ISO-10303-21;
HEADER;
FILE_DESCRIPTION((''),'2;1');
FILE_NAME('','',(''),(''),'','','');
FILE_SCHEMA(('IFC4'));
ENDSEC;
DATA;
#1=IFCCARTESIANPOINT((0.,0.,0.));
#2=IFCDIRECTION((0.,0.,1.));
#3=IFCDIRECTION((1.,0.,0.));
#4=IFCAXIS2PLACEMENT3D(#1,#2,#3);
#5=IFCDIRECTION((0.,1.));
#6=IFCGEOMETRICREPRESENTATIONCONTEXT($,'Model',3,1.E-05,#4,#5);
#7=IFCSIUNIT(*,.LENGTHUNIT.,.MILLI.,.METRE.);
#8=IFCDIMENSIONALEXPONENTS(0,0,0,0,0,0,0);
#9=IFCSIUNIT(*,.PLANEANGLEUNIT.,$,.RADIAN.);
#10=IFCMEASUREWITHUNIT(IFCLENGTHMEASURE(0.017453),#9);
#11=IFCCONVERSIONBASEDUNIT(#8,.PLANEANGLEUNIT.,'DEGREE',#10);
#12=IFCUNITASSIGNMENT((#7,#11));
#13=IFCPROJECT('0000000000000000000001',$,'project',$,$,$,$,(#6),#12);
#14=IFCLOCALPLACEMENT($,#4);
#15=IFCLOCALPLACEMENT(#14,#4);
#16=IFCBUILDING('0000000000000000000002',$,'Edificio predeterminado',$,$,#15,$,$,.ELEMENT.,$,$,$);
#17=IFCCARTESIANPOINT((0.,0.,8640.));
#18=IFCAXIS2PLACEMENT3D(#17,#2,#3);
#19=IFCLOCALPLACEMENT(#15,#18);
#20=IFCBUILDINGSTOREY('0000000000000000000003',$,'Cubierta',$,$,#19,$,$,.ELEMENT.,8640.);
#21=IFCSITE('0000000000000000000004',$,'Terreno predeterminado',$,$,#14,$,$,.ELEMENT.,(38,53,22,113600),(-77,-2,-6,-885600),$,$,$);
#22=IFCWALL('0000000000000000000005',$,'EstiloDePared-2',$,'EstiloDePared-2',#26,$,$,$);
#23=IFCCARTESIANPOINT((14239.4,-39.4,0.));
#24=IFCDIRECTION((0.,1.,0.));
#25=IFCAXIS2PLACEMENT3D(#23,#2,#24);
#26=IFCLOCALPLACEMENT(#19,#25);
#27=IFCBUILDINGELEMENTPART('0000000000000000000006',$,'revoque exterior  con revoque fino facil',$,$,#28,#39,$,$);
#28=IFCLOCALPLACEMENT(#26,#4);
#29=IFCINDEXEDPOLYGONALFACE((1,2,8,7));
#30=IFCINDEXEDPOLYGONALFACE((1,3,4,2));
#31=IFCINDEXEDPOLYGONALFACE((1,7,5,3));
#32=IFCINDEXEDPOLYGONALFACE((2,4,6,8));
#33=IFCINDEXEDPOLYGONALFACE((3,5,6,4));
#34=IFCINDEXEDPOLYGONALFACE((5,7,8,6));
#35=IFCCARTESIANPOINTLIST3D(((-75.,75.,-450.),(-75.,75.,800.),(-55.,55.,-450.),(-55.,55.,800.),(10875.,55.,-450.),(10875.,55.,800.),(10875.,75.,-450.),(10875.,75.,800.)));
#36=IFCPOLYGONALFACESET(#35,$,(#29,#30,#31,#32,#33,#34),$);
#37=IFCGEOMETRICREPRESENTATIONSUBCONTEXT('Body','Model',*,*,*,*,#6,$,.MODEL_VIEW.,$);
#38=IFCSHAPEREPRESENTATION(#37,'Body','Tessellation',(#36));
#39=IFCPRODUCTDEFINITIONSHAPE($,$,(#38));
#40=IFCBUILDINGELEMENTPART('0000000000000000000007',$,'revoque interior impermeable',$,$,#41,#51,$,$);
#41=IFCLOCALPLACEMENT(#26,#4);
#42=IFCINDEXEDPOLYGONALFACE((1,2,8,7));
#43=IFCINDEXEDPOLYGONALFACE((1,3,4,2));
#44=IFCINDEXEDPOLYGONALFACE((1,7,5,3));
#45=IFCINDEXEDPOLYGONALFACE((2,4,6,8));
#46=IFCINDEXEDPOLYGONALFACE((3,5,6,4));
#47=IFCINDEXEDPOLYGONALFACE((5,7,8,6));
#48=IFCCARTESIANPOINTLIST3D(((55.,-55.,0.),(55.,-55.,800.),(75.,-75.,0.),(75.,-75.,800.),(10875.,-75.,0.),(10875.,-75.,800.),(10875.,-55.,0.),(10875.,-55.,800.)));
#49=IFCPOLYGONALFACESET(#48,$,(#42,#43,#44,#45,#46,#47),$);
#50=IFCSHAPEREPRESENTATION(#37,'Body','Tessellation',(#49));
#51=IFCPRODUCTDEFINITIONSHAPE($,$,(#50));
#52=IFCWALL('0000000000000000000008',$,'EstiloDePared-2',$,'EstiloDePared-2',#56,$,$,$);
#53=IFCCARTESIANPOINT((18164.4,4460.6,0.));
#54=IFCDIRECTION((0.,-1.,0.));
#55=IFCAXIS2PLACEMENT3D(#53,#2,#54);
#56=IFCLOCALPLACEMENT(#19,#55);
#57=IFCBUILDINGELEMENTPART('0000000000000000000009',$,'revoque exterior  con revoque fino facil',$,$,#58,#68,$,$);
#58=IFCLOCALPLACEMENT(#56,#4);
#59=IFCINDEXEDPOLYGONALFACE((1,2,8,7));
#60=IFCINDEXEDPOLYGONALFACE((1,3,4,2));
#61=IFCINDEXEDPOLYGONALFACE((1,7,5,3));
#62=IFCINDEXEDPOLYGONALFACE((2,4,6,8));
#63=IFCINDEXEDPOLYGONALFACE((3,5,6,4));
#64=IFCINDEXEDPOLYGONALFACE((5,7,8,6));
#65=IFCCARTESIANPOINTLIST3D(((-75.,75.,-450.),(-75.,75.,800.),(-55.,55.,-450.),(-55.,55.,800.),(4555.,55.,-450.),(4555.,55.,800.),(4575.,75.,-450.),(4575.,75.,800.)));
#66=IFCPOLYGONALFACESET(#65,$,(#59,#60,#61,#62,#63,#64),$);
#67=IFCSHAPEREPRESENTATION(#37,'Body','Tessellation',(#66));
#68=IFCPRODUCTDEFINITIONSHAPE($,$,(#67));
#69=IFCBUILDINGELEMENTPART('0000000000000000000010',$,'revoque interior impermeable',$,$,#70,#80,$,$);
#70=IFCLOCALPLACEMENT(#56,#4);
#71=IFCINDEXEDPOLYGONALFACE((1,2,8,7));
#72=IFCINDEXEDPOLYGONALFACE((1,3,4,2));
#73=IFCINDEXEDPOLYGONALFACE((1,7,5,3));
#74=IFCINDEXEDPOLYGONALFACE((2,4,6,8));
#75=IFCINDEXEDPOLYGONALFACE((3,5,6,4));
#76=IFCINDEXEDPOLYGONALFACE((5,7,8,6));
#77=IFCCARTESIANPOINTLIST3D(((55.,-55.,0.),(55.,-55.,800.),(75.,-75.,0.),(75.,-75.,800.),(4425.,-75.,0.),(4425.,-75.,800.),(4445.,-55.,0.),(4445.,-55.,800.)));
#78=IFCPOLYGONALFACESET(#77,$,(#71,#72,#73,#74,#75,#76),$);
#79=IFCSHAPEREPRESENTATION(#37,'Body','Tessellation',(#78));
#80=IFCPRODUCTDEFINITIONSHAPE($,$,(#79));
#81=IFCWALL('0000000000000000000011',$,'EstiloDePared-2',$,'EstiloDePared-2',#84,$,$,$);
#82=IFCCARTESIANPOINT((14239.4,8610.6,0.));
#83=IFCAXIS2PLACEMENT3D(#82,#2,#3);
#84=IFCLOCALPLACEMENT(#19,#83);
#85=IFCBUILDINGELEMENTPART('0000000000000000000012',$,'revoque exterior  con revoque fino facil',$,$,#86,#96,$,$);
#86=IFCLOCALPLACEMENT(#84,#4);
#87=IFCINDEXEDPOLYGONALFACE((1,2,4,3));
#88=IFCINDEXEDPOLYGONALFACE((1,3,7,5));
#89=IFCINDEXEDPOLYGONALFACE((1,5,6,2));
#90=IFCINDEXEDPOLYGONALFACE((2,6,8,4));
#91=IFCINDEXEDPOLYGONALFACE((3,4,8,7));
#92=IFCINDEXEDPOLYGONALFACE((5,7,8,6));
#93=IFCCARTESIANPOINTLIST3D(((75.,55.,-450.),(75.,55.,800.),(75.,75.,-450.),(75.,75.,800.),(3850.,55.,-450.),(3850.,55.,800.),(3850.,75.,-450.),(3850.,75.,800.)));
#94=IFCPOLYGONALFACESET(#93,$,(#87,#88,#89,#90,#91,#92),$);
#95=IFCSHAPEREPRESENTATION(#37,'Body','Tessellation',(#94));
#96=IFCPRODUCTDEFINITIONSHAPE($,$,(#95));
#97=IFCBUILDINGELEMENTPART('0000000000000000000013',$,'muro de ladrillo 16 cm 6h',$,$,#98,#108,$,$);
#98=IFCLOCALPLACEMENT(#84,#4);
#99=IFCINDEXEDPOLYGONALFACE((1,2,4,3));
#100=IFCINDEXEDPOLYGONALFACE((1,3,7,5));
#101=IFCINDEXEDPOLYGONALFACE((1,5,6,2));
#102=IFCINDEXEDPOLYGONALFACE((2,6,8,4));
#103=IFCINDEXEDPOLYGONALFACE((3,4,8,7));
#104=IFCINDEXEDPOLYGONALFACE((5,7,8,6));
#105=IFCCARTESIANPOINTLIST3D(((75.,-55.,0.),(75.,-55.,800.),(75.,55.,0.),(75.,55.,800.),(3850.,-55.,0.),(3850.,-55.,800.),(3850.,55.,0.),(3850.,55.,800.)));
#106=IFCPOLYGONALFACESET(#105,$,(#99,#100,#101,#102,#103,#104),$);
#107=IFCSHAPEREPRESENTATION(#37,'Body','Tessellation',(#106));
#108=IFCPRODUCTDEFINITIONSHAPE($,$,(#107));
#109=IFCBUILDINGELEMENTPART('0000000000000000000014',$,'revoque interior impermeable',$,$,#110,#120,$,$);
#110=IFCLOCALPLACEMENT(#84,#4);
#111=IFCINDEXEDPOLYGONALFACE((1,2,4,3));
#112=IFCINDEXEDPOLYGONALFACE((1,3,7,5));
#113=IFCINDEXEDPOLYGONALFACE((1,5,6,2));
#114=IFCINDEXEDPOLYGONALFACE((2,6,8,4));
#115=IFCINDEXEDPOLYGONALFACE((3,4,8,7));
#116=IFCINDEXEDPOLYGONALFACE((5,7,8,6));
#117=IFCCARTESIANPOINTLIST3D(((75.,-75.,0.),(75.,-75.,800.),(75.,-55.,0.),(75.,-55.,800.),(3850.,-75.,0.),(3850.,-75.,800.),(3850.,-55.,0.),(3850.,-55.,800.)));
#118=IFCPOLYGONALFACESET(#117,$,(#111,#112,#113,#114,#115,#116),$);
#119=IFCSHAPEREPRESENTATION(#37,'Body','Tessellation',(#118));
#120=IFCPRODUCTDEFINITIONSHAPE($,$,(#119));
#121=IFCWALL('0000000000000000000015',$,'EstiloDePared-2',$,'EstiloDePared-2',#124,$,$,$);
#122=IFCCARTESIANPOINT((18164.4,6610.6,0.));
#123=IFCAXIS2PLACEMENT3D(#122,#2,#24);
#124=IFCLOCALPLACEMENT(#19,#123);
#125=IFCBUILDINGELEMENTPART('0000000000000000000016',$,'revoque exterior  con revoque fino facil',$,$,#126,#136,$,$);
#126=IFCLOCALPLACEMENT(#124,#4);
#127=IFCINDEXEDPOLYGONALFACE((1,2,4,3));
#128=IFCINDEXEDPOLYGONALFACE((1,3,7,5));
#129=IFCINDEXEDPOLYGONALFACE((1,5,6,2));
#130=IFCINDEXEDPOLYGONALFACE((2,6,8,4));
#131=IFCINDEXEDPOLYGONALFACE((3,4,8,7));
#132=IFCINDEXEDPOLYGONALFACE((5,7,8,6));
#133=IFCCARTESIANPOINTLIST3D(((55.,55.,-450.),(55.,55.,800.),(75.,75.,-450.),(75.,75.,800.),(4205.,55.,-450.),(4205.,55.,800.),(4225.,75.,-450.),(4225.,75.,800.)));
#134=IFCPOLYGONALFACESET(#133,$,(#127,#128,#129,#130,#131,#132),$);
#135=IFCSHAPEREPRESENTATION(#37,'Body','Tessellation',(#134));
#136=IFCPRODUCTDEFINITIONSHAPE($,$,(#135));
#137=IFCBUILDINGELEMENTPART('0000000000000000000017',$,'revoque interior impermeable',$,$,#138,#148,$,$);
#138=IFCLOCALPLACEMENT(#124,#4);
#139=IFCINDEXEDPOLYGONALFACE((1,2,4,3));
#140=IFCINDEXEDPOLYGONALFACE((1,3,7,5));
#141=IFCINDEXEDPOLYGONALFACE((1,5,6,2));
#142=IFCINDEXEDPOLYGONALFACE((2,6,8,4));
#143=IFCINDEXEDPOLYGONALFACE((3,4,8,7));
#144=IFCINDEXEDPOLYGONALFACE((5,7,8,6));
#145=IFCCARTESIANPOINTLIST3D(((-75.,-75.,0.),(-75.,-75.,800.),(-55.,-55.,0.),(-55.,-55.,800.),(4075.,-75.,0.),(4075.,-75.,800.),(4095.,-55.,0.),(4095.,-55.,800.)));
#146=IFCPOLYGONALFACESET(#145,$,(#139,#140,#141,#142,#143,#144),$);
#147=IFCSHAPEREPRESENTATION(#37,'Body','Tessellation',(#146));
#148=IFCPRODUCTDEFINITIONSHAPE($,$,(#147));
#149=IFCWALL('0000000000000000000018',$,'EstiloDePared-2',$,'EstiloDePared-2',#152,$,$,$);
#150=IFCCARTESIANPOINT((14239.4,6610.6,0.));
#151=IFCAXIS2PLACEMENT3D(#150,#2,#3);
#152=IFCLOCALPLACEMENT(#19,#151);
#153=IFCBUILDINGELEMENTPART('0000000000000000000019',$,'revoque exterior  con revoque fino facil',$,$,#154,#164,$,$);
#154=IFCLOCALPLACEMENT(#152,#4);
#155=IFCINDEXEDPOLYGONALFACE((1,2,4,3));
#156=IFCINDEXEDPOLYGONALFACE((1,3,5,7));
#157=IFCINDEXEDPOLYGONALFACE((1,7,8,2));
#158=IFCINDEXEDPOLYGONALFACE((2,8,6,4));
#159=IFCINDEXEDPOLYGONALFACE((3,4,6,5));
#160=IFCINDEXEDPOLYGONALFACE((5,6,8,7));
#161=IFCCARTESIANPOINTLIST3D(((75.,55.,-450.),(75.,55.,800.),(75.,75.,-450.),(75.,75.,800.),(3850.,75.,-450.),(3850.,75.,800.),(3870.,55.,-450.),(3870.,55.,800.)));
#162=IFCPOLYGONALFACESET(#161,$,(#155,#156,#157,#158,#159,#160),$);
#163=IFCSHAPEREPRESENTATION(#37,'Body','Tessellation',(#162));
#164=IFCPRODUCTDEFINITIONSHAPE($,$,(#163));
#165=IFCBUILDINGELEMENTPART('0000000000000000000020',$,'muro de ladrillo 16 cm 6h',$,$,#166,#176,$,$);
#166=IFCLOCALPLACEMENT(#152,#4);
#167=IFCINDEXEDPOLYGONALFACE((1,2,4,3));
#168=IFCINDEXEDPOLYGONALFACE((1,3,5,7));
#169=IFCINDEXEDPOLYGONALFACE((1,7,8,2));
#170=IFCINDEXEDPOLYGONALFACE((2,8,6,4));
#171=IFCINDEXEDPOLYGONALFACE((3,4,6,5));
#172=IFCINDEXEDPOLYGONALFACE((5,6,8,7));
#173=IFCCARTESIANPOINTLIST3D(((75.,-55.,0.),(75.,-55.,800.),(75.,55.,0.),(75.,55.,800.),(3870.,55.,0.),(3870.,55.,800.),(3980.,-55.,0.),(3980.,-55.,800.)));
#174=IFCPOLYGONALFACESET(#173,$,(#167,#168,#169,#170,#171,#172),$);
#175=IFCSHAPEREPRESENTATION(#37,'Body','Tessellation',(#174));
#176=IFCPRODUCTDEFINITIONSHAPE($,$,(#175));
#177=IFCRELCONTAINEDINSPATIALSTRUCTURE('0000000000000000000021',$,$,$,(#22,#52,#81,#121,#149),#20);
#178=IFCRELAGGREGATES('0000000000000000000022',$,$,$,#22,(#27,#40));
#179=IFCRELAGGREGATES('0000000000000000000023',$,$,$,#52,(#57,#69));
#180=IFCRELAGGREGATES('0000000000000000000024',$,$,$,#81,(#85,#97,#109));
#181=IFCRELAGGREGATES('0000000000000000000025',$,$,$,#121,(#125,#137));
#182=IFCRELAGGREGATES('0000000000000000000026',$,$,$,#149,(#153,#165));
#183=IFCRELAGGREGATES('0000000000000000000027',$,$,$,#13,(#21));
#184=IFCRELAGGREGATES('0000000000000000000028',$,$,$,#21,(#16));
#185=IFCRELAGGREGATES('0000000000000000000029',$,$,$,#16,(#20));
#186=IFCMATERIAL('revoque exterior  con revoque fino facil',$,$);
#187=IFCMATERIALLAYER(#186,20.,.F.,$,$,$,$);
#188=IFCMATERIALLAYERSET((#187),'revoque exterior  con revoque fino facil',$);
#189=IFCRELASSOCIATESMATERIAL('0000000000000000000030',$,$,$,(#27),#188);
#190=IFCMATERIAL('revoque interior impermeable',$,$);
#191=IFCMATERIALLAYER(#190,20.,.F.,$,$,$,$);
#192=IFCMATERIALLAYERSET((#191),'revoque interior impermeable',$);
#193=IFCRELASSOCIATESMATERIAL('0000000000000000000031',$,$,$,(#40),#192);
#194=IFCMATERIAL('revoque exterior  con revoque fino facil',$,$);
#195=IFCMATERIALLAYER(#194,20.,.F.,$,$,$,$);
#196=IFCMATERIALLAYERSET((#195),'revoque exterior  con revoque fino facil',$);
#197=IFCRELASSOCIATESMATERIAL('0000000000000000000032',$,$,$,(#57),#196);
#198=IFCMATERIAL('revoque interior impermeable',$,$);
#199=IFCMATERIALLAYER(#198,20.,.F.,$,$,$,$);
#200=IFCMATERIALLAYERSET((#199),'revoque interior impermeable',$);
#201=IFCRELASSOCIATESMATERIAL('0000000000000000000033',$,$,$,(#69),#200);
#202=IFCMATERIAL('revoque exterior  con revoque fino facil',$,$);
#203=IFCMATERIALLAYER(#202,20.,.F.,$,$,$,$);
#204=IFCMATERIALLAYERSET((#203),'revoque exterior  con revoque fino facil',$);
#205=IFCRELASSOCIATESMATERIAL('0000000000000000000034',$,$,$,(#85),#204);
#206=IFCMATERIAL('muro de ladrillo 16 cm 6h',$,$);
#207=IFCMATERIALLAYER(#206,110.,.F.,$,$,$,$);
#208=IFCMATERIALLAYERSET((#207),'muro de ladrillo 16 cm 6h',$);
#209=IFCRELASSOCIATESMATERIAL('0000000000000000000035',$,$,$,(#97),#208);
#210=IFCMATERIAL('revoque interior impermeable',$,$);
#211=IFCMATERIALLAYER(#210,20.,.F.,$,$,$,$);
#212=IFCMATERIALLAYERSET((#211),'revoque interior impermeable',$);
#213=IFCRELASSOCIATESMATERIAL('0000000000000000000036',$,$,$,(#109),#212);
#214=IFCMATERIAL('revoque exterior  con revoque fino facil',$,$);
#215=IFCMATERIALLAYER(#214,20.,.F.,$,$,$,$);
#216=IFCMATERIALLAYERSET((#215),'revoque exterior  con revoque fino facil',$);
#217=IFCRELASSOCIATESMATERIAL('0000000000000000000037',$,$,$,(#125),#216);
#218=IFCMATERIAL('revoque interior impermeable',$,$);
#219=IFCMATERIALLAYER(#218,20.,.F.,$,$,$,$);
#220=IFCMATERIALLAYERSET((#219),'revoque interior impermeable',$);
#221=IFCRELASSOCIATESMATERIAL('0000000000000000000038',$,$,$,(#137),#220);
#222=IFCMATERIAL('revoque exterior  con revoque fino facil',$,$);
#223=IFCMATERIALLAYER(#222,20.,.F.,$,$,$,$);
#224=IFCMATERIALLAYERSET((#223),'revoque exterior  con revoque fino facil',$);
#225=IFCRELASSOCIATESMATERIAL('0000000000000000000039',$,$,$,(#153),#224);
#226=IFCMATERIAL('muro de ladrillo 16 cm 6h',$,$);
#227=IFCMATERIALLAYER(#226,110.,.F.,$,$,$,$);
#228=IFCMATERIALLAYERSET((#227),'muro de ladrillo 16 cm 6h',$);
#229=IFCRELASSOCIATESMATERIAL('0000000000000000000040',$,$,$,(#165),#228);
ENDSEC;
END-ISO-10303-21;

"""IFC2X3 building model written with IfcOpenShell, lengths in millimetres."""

from ifc_helpers import new_model, entity, si_unit, converted_unit, direction, frame, origin_with_axes, place, context, subcontext, project, spatial, polyline, outline, extrude, material, layer, layer_set, layer_usage, element, aggregate, save


model = new_model("IFC2X3")

# Units and contexts
model_context = context("Model", 3, precision=1e-05, world=origin_with_axes(), true_north=direction((0.0, 1.0)))
body_context = subcontext(model_context, "Body", "Model", "MODEL_VIEW")
ifc_project = project(units=[si_unit("LENGTHUNIT", "METRE", prefix="MILLI"), converted_unit("PLANEANGLEUNIT", "DEGREE", entity("IfcLengthMeasure", 0.017453), si_unit("PLANEANGLEUNIT", "RADIAN"), dimensions=[0, 0, 0, 0, 0, 0, 0])], contexts=[model_context])

# Site, building, storey
site_placement = place(None, origin_with_axes())
site = spatial("IfcSite", under=ifc_project, at=site_placement, Name="Terreno predeterminado", CompositionType="ELEMENT", RefLatitude=(38, 53, 22, 113600), RefLongitude=(-77, -2, -6, -885600))
building_placement = place(site_placement, origin_with_axes())
building = spatial("IfcBuilding", under=site, at=building_placement, Name="Edificio predeterminado", CompositionType="ELEMENT")
storey_placement = place(building_placement, frame((0.0, 0.0, 8640.0), z_axis=(0.0, 0.0, 1.0), x_axis=(1.0, 0.0, 0.0)))
storey = spatial("IfcBuildingStorey", under=building, at=storey_placement, Name="Cubierta", CompositionType="ELEMENT", Elevation=8640.0)

# Walls, building element parts
wall_1_placement = place(storey_placement, frame((14239.4, -39.4, 0.0), z_axis=(0.0, 0.0, 1.0), x_axis=(0.0, 1.0, 0.0)))
wall_1 = element("IfcWall", 1, at=wall_1_placement, inside=storey, Name="EstiloDePared-2", ObjectType="EstiloDePared-2")
ifc_material_1 = material(Name="revoque exterior  con revoque fino facil")
ifc_layer_1 = layer(ifc_material_1, 20.0, ventilated=False)
ifc_layer_set_1 = layer_set([ifc_layer_1], Name="revoque exterior  con revoque fino facil")
ifc_layer_usage_1 = layer_usage(ifc_layer_set_1, "AXIS2", "NEGATIVE", -75.0)
building_element_part_1_placement = place(wall_1_placement, origin_with_axes())
building_element_part_1 = element("IfcBuildingElementPart", 2, at=building_element_part_1_placement, material=ifc_layer_usage_1, Name="revoque exterior  con revoque fino facil", context=body_context, shape_type="SweptSolid", body=[
    extrude(outline(polyline([(10875.0, 75.0), (10875.0, 55.0), (-55.0, 55.0), (-75.0, 75.0), (10875.0, 75.0)])), frame((0.0, 0.0, -450.0), z_axis=(0.0, 0.0, 1.0), x_axis=(1.0, 0.0, 0.0)), (0.0, 0.0, 1.0), 1250.0),
])
ifc_material_2 = material(Name="revoque interior impermeable")
ifc_layer_2 = layer(ifc_material_2, 20.0, ventilated=False)
ifc_layer_set_2 = layer_set([ifc_layer_2], Name="revoque interior impermeable")
ifc_layer_usage_2 = layer_usage(ifc_layer_set_2, "AXIS2", "NEGATIVE", 55.0)
building_element_part_2_placement = place(wall_1_placement, origin_with_axes())
building_element_part_2 = element("IfcBuildingElementPart", 3, at=building_element_part_2_placement, material=ifc_layer_usage_2, Name="revoque interior impermeable", context=body_context, shape_type="SweptSolid", body=[
    extrude(outline(polyline([(10875.0, -55.0), (10875.0, -75.0), (75.0, -75.0), (55.0, -55.0), (10875.0, -55.0)])), origin_with_axes(), (0.0, 0.0, 1.0), 800.0),
])
aggregate(wall_1, [building_element_part_1, building_element_part_2])
wall_2_placement = place(storey_placement, frame((18164.4, 4460.6, 0.0), z_axis=(0.0, 0.0, 1.0), x_axis=(0.0, -1.0, 0.0)))
wall_2 = element("IfcWall", 4, at=wall_2_placement, inside=storey, Name="EstiloDePared-2", ObjectType="EstiloDePared-2")
ifc_material_3 = material(Name="revoque exterior  con revoque fino facil")
ifc_layer_3 = layer(ifc_material_3, 20.0, ventilated=False)
ifc_layer_set_3 = layer_set([ifc_layer_3], Name="revoque exterior  con revoque fino facil")
ifc_layer_usage_3 = layer_usage(ifc_layer_set_3, "AXIS2", "NEGATIVE", -75.0)
building_element_part_3_placement = place(wall_2_placement, origin_with_axes())
building_element_part_3 = element("IfcBuildingElementPart", 5, at=building_element_part_3_placement, material=ifc_layer_usage_3, Name="revoque exterior  con revoque fino facil", context=body_context, shape_type="SweptSolid", body=[
    extrude(outline(polyline([(4575.0, 75.0), (4555.0, 55.0), (-55.0, 55.0), (-75.0, 75.0), (4575.0, 75.0)])), frame((0.0, 0.0, -450.0), z_axis=(0.0, 0.0, 1.0), x_axis=(1.0, 0.0, 0.0)), (0.0, 0.0, 1.0), 1250.0),
])
ifc_material_4 = material(Name="revoque interior impermeable")
ifc_layer_4 = layer(ifc_material_4, 20.0, ventilated=False)
ifc_layer_set_4 = layer_set([ifc_layer_4], Name="revoque interior impermeable")
ifc_layer_usage_4 = layer_usage(ifc_layer_set_4, "AXIS2", "NEGATIVE", 55.0)
building_element_part_4_placement = place(wall_2_placement, origin_with_axes())
building_element_part_4 = element("IfcBuildingElementPart", 6, at=building_element_part_4_placement, material=ifc_layer_usage_4, Name="revoque interior impermeable", context=body_context, shape_type="SweptSolid", body=[
    extrude(outline(polyline([(4445.0, -55.0), (4425.0, -75.0), (75.0, -75.0), (55.0, -55.0), (4445.0, -55.0)])), origin_with_axes(), (0.0, 0.0, 1.0), 800.0),
])
aggregate(wall_2, [building_element_part_3, building_element_part_4])
wall_3_placement = place(storey_placement, frame((14239.4, 8610.6, 0.0), z_axis=(0.0, 0.0, 1.0), x_axis=(1.0, 0.0, 0.0)))
wall_3 = element("IfcWall", 7, at=wall_3_placement, inside=storey, Name="EstiloDePared-2", ObjectType="EstiloDePared-2")
ifc_material_5 = material(Name="revoque exterior  con revoque fino facil")
ifc_layer_5 = layer(ifc_material_5, 20.0, ventilated=False)
ifc_layer_set_5 = layer_set([ifc_layer_5], Name="revoque exterior  con revoque fino facil")
ifc_layer_usage_5 = layer_usage(ifc_layer_set_5, "AXIS2", "NEGATIVE", -75.0)
building_element_part_5_placement = place(wall_3_placement, origin_with_axes())
building_element_part_5 = element("IfcBuildingElementPart", 8, at=building_element_part_5_placement, material=ifc_layer_usage_5, Name="revoque exterior  con revoque fino facil", context=body_context, shape_type="SweptSolid", body=[
    extrude(outline(polyline([(3850.0, 75.0), (3850.0, 55.0), (75.0, 55.0), (75.0, 75.0), (3850.0, 75.0)])), frame((0.0, 0.0, -450.0), z_axis=(0.0, 0.0, 1.0), x_axis=(1.0, 0.0, 0.0)), (0.0, 0.0, 1.0), 1250.0),
])
ifc_material_6 = material(Name="muro de ladrillo 16 cm 6h")
ifc_layer_6 = layer(ifc_material_6, 110.0, ventilated=False)
ifc_layer_set_6 = layer_set([ifc_layer_6], Name="muro de ladrillo 16 cm 6h")
ifc_layer_usage_6 = layer_usage(ifc_layer_set_6, "AXIS2", "NEGATIVE", -55.0)
building_element_part_6_placement = place(wall_3_placement, origin_with_axes())
building_element_part_6 = element("IfcBuildingElementPart", 9, at=building_element_part_6_placement, material=ifc_layer_usage_6, Name="muro de ladrillo 16 cm 6h", context=body_context, shape_type="SweptSolid", body=[
    extrude(outline(polyline([(3850.0, 55.0), (3850.0, -55.0), (75.0, -55.0), (75.0, 55.0), (3850.0, 55.0)])), origin_with_axes(), (0.0, 0.0, 1.0), 800.0),
])
ifc_material_7 = material(Name="revoque interior impermeable")
ifc_layer_7 = layer(ifc_material_7, 20.0, ventilated=False)
ifc_layer_set_7 = layer_set([ifc_layer_7], Name="revoque interior impermeable")
ifc_layer_usage_7 = layer_usage(ifc_layer_set_7, "AXIS2", "NEGATIVE", 55.0)
building_element_part_7_placement = place(wall_3_placement, origin_with_axes())
building_element_part_7 = element("IfcBuildingElementPart", 10, at=building_element_part_7_placement, material=ifc_layer_usage_7, Name="revoque interior impermeable", context=body_context, shape_type="SweptSolid", body=[
    extrude(outline(polyline([(3850.0, -55.0), (3850.0, -75.0), (75.0, -75.0), (75.0, -55.0), (3850.0, -55.0)])), origin_with_axes(), (0.0, 0.0, 1.0), 800.0),
])
aggregate(wall_3, [building_element_part_5, building_element_part_6, building_element_part_7])
wall_4_placement = place(storey_placement, frame((18164.4, 6610.6, 0.0), z_axis=(0.0, 0.0, 1.0), x_axis=(0.0, 1.0, 0.0)))
wall_4 = element("IfcWall", 11, at=wall_4_placement, inside=storey, Name="EstiloDePared-2", ObjectType="EstiloDePared-2")
ifc_material_8 = material(Name="revoque exterior  con revoque fino facil")
ifc_layer_8 = layer(ifc_material_8, 20.0, ventilated=False)
ifc_layer_set_8 = layer_set([ifc_layer_8], Name="revoque exterior  con revoque fino facil")
ifc_layer_usage_8 = layer_usage(ifc_layer_set_8, "AXIS2", "NEGATIVE", -75.0)
building_element_part_8_placement = place(wall_4_placement, origin_with_axes())
building_element_part_8 = element("IfcBuildingElementPart", 12, at=building_element_part_8_placement, material=ifc_layer_usage_8, Name="revoque exterior  con revoque fino facil", context=body_context, shape_type="SweptSolid", body=[
    extrude(outline(polyline([(4225.0, 75.0), (4205.0, 55.0), (55.0, 55.0), (75.0, 75.0), (4225.0, 75.0)])), frame((0.0, 0.0, -450.0), z_axis=(0.0, 0.0, 1.0), x_axis=(1.0, 0.0, 0.0)), (0.0, 0.0, 1.0), 1250.0),
])
ifc_material_9 = material(Name="revoque interior impermeable")
ifc_layer_9 = layer(ifc_material_9, 20.0, ventilated=False)
ifc_layer_set_9 = layer_set([ifc_layer_9], Name="revoque interior impermeable")
ifc_layer_usage_9 = layer_usage(ifc_layer_set_9, "AXIS2", "NEGATIVE", 55.0)
building_element_part_9_placement = place(wall_4_placement, origin_with_axes())
building_element_part_9 = element("IfcBuildingElementPart", 13, at=building_element_part_9_placement, material=ifc_layer_usage_9, Name="revoque interior impermeable", context=body_context, shape_type="SweptSolid", body=[
    extrude(outline(polyline([(4095.0, -55.0), (4075.0, -75.0), (-75.0, -75.0), (-55.0, -55.0), (4095.0, -55.0)])), origin_with_axes(), (0.0, 0.0, 1.0), 800.0),
])
aggregate(wall_4, [building_element_part_8, building_element_part_9])
wall_5_placement = place(storey_placement, frame((14239.4, 6610.6, 0.0), z_axis=(0.0, 0.0, 1.0), x_axis=(1.0, 0.0, 0.0)))
wall_5 = element("IfcWall", 14, at=wall_5_placement, inside=storey, Name="EstiloDePared-2", ObjectType="EstiloDePared-2")
ifc_material_10 = material(Name="revoque exterior  con revoque fino facil")
ifc_layer_10 = layer(ifc_material_10, 20.0, ventilated=False)
ifc_layer_set_10 = layer_set([ifc_layer_10], Name="revoque exterior  con revoque fino facil")
ifc_layer_usage_10 = layer_usage(ifc_layer_set_10, "AXIS2", "NEGATIVE", -75.0)
building_element_part_10_placement = place(wall_5_placement, origin_with_axes())
building_element_part_10 = element("IfcBuildingElementPart", 15, at=building_element_part_10_placement, material=ifc_layer_usage_10, Name="revoque exterior  con revoque fino facil", context=body_context, shape_type="SweptSolid", body=[
    extrude(outline(polyline([(3850.0, 75.0), (3870.0, 55.0), (75.0, 55.0), (75.0, 75.0), (3850.0, 75.0)])), frame((0.0, 0.0, -450.0), z_axis=(0.0, 0.0, 1.0), x_axis=(1.0, 0.0, 0.0)), (0.0, 0.0, 1.0), 1250.0),
])
ifc_material_11 = material(Name="muro de ladrillo 16 cm 6h")
ifc_layer_11 = layer(ifc_material_11, 110.0, ventilated=False)
ifc_layer_set_11 = layer_set([ifc_layer_11], Name="muro de ladrillo 16 cm 6h")
ifc_layer_usage_11 = layer_usage(ifc_layer_set_11, "AXIS2", "NEGATIVE", -55.0)
building_element_part_11_placement = place(wall_5_placement, origin_with_axes())
building_element_part_11 = element("IfcBuildingElementPart", 16, at=building_element_part_11_placement, material=ifc_layer_usage_11, Name="muro de ladrillo 16 cm 6h", context=body_context, shape_type="SweptSolid", body=[
    extrude(outline(polyline([(3870.0, 55.0), (3980.0, -55.0), (75.0, -55.0), (75.0, 55.0), (3870.0, 55.0)])), origin_with_axes(), (0.0, 0.0, 1.0), 800.0),
])
aggregate(wall_5, [building_element_part_10, building_element_part_11])

save(model, "model.ifc")
